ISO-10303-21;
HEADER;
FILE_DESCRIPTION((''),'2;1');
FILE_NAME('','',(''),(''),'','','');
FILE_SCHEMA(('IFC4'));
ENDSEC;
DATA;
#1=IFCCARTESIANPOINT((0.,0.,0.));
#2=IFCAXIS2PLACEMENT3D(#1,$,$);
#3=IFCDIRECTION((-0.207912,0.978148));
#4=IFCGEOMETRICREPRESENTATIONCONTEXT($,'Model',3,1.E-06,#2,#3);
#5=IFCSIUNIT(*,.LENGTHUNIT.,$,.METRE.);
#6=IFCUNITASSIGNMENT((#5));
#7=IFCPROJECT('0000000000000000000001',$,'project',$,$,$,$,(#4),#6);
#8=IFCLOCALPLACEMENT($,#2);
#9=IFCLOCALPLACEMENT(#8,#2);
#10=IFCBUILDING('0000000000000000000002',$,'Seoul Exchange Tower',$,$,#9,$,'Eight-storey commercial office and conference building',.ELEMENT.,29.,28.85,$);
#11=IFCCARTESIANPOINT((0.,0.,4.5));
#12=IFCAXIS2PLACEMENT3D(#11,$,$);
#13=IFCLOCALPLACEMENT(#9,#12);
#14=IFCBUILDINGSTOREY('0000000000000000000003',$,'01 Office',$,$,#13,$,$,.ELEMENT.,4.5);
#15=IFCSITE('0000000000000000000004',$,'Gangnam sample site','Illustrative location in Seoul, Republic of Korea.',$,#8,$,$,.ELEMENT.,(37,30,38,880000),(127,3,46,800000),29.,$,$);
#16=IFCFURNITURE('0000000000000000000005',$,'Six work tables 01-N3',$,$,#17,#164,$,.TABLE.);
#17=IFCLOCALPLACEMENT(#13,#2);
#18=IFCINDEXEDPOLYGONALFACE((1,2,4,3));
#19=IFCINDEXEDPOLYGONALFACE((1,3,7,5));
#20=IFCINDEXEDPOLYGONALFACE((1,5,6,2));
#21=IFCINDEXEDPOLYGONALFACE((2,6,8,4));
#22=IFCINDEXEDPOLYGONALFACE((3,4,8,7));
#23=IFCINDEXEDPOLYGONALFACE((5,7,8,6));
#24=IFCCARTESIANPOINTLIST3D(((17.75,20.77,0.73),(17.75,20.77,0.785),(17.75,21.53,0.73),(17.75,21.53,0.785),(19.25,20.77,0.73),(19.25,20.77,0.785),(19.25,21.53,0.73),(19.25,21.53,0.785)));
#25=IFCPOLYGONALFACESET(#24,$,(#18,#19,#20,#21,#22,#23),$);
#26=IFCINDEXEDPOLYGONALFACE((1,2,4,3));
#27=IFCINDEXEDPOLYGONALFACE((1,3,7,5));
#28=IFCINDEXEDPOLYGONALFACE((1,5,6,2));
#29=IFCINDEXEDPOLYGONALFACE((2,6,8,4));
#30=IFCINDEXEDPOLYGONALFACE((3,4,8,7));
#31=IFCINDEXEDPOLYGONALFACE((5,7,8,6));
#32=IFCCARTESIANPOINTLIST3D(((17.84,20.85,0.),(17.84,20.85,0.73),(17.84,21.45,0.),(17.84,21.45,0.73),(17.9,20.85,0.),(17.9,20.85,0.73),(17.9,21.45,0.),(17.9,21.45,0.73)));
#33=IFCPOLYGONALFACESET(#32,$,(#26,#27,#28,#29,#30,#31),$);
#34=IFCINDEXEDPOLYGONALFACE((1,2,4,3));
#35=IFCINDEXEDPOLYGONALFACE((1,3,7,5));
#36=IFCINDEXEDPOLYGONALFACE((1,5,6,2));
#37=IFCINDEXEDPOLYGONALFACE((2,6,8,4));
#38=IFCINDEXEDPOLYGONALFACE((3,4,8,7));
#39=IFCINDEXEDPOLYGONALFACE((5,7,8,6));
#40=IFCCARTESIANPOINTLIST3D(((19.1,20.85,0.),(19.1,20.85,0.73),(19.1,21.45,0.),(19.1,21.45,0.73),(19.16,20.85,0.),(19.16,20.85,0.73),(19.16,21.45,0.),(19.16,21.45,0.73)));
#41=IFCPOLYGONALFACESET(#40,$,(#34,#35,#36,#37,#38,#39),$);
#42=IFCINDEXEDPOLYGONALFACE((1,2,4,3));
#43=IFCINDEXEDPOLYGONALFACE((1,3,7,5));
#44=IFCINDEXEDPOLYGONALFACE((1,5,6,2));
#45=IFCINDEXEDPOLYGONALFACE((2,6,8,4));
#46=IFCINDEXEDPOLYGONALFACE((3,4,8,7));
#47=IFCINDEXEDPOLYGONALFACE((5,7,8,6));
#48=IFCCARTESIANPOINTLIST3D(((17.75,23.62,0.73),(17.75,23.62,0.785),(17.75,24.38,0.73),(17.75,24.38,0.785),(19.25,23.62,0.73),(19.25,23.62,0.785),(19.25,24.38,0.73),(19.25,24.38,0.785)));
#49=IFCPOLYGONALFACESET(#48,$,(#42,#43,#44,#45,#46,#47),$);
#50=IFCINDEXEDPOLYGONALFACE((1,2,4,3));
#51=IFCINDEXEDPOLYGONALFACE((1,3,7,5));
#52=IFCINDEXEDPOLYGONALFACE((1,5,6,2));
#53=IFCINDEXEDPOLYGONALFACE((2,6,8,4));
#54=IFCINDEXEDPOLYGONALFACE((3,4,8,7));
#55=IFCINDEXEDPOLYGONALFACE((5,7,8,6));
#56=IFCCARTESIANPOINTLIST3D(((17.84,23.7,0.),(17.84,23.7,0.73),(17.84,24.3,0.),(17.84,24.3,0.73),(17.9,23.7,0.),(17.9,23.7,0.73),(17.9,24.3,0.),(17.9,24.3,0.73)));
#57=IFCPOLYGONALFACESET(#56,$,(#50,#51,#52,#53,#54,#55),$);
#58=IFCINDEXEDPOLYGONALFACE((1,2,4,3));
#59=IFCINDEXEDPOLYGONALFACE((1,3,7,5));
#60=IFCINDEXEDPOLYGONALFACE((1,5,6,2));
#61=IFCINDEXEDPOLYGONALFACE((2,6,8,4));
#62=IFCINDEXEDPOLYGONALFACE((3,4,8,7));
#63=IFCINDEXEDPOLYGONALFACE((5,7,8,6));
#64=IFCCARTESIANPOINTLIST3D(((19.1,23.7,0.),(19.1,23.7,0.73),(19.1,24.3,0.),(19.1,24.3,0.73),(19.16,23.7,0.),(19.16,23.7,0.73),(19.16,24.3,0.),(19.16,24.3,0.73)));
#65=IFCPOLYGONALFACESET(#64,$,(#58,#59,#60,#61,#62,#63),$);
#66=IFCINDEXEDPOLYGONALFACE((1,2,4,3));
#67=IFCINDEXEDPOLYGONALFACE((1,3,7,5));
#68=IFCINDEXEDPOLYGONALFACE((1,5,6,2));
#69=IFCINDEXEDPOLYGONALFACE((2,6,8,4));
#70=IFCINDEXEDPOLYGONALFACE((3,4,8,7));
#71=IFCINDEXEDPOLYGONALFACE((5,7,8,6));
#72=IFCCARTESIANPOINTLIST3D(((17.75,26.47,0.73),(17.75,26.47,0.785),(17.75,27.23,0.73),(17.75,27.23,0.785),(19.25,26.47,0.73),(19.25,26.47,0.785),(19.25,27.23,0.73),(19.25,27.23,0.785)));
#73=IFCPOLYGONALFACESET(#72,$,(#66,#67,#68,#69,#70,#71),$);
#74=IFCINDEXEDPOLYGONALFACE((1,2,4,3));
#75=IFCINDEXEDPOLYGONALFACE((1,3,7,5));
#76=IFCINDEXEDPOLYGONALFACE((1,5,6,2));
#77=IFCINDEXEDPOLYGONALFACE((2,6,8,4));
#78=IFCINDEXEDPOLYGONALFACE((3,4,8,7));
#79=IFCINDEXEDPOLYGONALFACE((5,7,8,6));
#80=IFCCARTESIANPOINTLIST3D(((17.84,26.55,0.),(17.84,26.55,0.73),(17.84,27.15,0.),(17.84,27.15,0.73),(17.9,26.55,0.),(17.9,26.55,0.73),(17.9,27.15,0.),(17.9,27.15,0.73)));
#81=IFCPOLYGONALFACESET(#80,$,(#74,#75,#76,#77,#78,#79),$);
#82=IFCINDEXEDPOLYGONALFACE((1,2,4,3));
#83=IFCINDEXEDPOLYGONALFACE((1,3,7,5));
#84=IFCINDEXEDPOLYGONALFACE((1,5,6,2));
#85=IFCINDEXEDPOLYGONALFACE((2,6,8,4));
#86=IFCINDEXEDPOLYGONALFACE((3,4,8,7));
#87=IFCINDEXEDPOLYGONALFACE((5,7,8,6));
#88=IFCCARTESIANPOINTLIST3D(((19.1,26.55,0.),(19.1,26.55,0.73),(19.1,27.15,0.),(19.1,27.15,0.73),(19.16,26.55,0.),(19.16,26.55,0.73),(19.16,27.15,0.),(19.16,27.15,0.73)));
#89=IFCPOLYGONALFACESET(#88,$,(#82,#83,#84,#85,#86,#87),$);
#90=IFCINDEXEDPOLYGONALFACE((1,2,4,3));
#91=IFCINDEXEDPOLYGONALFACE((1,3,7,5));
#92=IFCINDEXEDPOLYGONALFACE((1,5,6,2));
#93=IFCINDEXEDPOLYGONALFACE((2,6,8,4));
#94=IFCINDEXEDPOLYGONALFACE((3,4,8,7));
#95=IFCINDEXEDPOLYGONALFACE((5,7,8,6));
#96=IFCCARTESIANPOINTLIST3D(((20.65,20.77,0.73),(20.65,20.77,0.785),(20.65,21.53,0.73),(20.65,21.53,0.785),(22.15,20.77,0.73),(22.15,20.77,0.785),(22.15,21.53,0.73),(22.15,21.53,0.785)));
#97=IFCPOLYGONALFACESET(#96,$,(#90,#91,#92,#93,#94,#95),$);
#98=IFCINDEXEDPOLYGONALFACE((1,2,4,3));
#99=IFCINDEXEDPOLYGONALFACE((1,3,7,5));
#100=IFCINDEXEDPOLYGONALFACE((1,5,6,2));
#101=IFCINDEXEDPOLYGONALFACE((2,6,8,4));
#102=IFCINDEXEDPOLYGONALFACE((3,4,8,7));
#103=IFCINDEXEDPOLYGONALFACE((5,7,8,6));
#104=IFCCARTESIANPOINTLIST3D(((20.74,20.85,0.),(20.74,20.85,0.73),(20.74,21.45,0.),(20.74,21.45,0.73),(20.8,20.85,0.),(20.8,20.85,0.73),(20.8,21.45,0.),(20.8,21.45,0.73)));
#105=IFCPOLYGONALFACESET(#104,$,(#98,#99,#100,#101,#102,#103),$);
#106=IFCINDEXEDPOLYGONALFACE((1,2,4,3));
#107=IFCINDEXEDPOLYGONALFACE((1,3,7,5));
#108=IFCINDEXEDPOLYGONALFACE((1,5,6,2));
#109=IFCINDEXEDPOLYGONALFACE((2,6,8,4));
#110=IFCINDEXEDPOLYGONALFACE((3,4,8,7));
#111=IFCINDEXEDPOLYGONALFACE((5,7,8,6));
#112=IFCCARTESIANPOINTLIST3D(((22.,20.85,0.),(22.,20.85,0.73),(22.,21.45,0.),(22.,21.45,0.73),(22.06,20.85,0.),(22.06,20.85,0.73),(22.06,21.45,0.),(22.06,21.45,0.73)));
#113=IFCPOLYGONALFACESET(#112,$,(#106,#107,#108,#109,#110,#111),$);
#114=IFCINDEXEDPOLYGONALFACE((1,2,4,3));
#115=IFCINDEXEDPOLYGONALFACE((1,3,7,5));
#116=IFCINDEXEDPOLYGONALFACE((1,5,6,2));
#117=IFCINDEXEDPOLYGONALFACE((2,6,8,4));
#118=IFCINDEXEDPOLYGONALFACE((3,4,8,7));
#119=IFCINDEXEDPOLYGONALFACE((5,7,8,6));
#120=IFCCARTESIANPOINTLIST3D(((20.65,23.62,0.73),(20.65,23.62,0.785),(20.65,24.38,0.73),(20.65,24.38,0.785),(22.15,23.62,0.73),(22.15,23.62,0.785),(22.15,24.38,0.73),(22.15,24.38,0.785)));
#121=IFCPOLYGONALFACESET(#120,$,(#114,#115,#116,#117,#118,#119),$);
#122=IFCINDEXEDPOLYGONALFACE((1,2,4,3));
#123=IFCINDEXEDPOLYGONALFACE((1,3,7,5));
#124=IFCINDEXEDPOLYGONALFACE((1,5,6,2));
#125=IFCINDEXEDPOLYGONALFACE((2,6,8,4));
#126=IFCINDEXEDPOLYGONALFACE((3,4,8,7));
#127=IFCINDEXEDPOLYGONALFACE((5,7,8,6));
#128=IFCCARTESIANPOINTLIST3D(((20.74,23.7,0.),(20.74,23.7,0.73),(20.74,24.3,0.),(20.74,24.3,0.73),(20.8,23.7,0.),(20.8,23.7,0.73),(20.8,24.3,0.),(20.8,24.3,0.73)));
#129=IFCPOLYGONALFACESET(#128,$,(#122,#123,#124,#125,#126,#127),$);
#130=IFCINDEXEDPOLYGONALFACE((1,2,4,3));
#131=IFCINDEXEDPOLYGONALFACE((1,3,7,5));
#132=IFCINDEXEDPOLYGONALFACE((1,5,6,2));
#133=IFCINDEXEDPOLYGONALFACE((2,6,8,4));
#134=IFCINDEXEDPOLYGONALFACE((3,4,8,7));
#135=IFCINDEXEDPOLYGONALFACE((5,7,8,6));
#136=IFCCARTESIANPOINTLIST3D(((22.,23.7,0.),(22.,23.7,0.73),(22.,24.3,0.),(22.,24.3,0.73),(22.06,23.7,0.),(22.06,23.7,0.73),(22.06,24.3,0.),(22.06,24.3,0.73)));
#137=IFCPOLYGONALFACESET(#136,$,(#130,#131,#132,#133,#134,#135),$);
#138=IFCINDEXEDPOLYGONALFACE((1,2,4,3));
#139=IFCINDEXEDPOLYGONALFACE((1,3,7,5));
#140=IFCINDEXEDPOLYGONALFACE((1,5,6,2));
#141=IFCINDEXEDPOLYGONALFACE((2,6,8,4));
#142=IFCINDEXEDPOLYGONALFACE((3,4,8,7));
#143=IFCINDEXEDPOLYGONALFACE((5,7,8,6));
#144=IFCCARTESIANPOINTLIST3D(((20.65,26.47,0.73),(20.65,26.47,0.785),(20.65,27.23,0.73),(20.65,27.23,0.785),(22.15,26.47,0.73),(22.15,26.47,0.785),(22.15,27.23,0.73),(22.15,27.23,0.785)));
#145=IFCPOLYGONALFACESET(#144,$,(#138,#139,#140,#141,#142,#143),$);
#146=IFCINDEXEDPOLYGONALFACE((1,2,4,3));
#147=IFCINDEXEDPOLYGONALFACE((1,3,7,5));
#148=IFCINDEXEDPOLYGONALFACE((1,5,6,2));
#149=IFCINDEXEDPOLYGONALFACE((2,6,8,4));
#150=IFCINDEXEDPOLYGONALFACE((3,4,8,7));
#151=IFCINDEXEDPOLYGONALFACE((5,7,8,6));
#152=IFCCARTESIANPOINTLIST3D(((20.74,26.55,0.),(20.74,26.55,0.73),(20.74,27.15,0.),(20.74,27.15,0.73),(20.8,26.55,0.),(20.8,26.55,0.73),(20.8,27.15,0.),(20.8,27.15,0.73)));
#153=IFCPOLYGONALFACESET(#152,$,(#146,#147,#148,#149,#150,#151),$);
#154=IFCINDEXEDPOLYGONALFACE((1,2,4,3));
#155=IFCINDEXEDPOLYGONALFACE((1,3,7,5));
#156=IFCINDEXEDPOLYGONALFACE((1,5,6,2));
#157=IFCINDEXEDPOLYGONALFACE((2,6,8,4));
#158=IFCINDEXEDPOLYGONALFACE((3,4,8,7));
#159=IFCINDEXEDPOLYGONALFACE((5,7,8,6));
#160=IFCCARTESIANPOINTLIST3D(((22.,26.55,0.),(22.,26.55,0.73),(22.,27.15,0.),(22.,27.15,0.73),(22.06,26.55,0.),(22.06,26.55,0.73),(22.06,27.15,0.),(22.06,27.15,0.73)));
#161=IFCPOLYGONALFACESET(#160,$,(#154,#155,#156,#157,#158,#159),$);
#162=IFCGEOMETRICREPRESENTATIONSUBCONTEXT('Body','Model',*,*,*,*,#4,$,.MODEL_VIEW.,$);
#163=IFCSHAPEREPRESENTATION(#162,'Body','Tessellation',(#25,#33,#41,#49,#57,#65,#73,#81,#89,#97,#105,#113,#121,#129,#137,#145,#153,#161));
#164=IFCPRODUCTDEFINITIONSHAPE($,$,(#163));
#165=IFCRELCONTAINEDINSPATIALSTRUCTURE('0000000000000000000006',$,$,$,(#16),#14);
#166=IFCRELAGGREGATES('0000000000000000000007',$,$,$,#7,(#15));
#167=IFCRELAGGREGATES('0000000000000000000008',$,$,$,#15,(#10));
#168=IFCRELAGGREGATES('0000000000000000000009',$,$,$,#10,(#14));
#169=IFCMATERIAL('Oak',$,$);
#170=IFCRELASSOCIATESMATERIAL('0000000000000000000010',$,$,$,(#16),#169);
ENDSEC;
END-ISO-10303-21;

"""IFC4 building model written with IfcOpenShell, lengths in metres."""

from ifc_helpers import new_model, si_unit, direction, frame, frame_2d, origin, place, context, subcontext, project, spatial, rectangle, extrude, material, element, save


model = new_model("IFC4")

# Units and contexts
model_context = context("Model", 3, precision=1e-06, world=origin(), true_north=direction((-0.207912, 0.978148)))
body_context = subcontext(model_context, "Body", "Model", "MODEL_VIEW")
ifc_project = project(units=[si_unit("LENGTHUNIT", "METRE")], contexts=[model_context])

# Site, building, storey
site_placement = place(None, origin())
site = spatial("IfcSite", under=ifc_project, at=site_placement, Name="Gangnam sample site", Description="Illustrative location in Seoul, Republic of Korea.", CompositionType="ELEMENT", RefLatitude=(37, 30, 38, 880000), RefLongitude=(127, 3, 46, 800000), RefElevation=29.0)
building_placement = place(site_placement, origin())
building = spatial("IfcBuilding", under=site, at=building_placement, Name="Seoul Exchange Tower", LongName="Eight-storey commercial office and conference building", CompositionType="ELEMENT", ElevationOfRefHeight=29.0, ElevationOfTerrain=28.85)
storey_placement = place(building_placement, frame((0.0, 0.0, 4.5)))
storey = spatial("IfcBuildingStorey", under=building, at=storey_placement, Name="01 Office", CompositionType="ELEMENT", Elevation=4.5)

# Shared definitions
placement_1 = place(storey_placement, origin())

# Furniture
ifc_material_1 = material(Name="Oak")
element("IfcFurniture", 1, at=placement_1, inside=storey, material=ifc_material_1, Name="Six work tables 01-N3", PredefinedType="TABLE", context=body_context, shape_type="SweptSolid", body=[
    extrude(rectangle(XDim=1.5, YDim=0.76, at=frame_2d((0.75, 0.38))), frame((17.75, 20.77, 0.73)), (0.0, 0.0, 1.0), 0.055),
    extrude(rectangle(XDim=0.06, YDim=0.6, at=frame_2d((0.03, 0.3))), frame((17.84, 20.85, 0.0)), (0.0, 0.0, 1.0), 0.73),
    extrude(rectangle(XDim=0.06, YDim=0.6, at=frame_2d((0.03, 0.3))), frame((19.1, 20.85, 0.0)), (0.0, 0.0, 1.0), 0.73),
    extrude(rectangle(XDim=1.5, YDim=0.76, at=frame_2d((0.75, 0.38))), frame((17.75, 23.62, 0.73)), (0.0, 0.0, 1.0), 0.055),
    extrude(rectangle(XDim=0.06, YDim=0.6, at=frame_2d((0.03, 0.3))), frame((17.84, 23.7, 0.0)), (0.0, 0.0, 1.0), 0.73),
    extrude(rectangle(XDim=0.06, YDim=0.6, at=frame_2d((0.03, 0.3))), frame((19.1, 23.7, 0.0)), (0.0, 0.0, 1.0), 0.73),
    extrude(rectangle(XDim=1.5, YDim=0.76, at=frame_2d((0.75, 0.38))), frame((17.75, 26.47, 0.73)), (0.0, 0.0, 1.0), 0.055),
    extrude(rectangle(XDim=0.06, YDim=0.6, at=frame_2d((0.03, 0.3))), frame((17.84, 26.55, 0.0)), (0.0, 0.0, 1.0), 0.73),
    extrude(rectangle(XDim=0.06, YDim=0.6, at=frame_2d((0.03, 0.3))), frame((19.1, 26.55, 0.0)), (0.0, 0.0, 1.0), 0.73),
    extrude(rectangle(XDim=1.5, YDim=0.76, at=frame_2d((0.75, 0.38))), frame((20.65, 20.77, 0.73)), (0.0, 0.0, 1.0), 0.055),
    extrude(rectangle(XDim=0.06, YDim=0.6, at=frame_2d((0.03, 0.3))), frame((20.74, 20.85, 0.0)), (0.0, 0.0, 1.0), 0.73),
    extrude(rectangle(XDim=0.06, YDim=0.6, at=frame_2d((0.03, 0.3))), frame((22.0, 20.85, 0.0)), (0.0, 0.0, 1.0), 0.73),
    extrude(rectangle(XDim=1.5, YDim=0.76, at=frame_2d((0.75, 0.38))), frame((20.65, 23.62, 0.73)), (0.0, 0.0, 1.0), 0.055),
    extrude(rectangle(XDim=0.06, YDim=0.6, at=frame_2d((0.03, 0.3))), frame((20.74, 23.7, 0.0)), (0.0, 0.0, 1.0), 0.73),
    extrude(rectangle(XDim=0.06, YDim=0.6, at=frame_2d((0.03, 0.3))), frame((22.0, 23.7, 0.0)), (0.0, 0.0, 1.0), 0.73),
    extrude(rectangle(XDim=1.5, YDim=0.76, at=frame_2d((0.75, 0.38))), frame((20.65, 26.47, 0.73)), (0.0, 0.0, 1.0), 0.055),
    extrude(rectangle(XDim=0.06, YDim=0.6, at=frame_2d((0.03, 0.3))), frame((20.74, 26.55, 0.0)), (0.0, 0.0, 1.0), 0.73),
    extrude(rectangle(XDim=0.06, YDim=0.6, at=frame_2d((0.03, 0.3))), frame((22.0, 26.55, 0.0)), (0.0, 0.0, 1.0), 0.73),
])

save(model, "model.ifc")
